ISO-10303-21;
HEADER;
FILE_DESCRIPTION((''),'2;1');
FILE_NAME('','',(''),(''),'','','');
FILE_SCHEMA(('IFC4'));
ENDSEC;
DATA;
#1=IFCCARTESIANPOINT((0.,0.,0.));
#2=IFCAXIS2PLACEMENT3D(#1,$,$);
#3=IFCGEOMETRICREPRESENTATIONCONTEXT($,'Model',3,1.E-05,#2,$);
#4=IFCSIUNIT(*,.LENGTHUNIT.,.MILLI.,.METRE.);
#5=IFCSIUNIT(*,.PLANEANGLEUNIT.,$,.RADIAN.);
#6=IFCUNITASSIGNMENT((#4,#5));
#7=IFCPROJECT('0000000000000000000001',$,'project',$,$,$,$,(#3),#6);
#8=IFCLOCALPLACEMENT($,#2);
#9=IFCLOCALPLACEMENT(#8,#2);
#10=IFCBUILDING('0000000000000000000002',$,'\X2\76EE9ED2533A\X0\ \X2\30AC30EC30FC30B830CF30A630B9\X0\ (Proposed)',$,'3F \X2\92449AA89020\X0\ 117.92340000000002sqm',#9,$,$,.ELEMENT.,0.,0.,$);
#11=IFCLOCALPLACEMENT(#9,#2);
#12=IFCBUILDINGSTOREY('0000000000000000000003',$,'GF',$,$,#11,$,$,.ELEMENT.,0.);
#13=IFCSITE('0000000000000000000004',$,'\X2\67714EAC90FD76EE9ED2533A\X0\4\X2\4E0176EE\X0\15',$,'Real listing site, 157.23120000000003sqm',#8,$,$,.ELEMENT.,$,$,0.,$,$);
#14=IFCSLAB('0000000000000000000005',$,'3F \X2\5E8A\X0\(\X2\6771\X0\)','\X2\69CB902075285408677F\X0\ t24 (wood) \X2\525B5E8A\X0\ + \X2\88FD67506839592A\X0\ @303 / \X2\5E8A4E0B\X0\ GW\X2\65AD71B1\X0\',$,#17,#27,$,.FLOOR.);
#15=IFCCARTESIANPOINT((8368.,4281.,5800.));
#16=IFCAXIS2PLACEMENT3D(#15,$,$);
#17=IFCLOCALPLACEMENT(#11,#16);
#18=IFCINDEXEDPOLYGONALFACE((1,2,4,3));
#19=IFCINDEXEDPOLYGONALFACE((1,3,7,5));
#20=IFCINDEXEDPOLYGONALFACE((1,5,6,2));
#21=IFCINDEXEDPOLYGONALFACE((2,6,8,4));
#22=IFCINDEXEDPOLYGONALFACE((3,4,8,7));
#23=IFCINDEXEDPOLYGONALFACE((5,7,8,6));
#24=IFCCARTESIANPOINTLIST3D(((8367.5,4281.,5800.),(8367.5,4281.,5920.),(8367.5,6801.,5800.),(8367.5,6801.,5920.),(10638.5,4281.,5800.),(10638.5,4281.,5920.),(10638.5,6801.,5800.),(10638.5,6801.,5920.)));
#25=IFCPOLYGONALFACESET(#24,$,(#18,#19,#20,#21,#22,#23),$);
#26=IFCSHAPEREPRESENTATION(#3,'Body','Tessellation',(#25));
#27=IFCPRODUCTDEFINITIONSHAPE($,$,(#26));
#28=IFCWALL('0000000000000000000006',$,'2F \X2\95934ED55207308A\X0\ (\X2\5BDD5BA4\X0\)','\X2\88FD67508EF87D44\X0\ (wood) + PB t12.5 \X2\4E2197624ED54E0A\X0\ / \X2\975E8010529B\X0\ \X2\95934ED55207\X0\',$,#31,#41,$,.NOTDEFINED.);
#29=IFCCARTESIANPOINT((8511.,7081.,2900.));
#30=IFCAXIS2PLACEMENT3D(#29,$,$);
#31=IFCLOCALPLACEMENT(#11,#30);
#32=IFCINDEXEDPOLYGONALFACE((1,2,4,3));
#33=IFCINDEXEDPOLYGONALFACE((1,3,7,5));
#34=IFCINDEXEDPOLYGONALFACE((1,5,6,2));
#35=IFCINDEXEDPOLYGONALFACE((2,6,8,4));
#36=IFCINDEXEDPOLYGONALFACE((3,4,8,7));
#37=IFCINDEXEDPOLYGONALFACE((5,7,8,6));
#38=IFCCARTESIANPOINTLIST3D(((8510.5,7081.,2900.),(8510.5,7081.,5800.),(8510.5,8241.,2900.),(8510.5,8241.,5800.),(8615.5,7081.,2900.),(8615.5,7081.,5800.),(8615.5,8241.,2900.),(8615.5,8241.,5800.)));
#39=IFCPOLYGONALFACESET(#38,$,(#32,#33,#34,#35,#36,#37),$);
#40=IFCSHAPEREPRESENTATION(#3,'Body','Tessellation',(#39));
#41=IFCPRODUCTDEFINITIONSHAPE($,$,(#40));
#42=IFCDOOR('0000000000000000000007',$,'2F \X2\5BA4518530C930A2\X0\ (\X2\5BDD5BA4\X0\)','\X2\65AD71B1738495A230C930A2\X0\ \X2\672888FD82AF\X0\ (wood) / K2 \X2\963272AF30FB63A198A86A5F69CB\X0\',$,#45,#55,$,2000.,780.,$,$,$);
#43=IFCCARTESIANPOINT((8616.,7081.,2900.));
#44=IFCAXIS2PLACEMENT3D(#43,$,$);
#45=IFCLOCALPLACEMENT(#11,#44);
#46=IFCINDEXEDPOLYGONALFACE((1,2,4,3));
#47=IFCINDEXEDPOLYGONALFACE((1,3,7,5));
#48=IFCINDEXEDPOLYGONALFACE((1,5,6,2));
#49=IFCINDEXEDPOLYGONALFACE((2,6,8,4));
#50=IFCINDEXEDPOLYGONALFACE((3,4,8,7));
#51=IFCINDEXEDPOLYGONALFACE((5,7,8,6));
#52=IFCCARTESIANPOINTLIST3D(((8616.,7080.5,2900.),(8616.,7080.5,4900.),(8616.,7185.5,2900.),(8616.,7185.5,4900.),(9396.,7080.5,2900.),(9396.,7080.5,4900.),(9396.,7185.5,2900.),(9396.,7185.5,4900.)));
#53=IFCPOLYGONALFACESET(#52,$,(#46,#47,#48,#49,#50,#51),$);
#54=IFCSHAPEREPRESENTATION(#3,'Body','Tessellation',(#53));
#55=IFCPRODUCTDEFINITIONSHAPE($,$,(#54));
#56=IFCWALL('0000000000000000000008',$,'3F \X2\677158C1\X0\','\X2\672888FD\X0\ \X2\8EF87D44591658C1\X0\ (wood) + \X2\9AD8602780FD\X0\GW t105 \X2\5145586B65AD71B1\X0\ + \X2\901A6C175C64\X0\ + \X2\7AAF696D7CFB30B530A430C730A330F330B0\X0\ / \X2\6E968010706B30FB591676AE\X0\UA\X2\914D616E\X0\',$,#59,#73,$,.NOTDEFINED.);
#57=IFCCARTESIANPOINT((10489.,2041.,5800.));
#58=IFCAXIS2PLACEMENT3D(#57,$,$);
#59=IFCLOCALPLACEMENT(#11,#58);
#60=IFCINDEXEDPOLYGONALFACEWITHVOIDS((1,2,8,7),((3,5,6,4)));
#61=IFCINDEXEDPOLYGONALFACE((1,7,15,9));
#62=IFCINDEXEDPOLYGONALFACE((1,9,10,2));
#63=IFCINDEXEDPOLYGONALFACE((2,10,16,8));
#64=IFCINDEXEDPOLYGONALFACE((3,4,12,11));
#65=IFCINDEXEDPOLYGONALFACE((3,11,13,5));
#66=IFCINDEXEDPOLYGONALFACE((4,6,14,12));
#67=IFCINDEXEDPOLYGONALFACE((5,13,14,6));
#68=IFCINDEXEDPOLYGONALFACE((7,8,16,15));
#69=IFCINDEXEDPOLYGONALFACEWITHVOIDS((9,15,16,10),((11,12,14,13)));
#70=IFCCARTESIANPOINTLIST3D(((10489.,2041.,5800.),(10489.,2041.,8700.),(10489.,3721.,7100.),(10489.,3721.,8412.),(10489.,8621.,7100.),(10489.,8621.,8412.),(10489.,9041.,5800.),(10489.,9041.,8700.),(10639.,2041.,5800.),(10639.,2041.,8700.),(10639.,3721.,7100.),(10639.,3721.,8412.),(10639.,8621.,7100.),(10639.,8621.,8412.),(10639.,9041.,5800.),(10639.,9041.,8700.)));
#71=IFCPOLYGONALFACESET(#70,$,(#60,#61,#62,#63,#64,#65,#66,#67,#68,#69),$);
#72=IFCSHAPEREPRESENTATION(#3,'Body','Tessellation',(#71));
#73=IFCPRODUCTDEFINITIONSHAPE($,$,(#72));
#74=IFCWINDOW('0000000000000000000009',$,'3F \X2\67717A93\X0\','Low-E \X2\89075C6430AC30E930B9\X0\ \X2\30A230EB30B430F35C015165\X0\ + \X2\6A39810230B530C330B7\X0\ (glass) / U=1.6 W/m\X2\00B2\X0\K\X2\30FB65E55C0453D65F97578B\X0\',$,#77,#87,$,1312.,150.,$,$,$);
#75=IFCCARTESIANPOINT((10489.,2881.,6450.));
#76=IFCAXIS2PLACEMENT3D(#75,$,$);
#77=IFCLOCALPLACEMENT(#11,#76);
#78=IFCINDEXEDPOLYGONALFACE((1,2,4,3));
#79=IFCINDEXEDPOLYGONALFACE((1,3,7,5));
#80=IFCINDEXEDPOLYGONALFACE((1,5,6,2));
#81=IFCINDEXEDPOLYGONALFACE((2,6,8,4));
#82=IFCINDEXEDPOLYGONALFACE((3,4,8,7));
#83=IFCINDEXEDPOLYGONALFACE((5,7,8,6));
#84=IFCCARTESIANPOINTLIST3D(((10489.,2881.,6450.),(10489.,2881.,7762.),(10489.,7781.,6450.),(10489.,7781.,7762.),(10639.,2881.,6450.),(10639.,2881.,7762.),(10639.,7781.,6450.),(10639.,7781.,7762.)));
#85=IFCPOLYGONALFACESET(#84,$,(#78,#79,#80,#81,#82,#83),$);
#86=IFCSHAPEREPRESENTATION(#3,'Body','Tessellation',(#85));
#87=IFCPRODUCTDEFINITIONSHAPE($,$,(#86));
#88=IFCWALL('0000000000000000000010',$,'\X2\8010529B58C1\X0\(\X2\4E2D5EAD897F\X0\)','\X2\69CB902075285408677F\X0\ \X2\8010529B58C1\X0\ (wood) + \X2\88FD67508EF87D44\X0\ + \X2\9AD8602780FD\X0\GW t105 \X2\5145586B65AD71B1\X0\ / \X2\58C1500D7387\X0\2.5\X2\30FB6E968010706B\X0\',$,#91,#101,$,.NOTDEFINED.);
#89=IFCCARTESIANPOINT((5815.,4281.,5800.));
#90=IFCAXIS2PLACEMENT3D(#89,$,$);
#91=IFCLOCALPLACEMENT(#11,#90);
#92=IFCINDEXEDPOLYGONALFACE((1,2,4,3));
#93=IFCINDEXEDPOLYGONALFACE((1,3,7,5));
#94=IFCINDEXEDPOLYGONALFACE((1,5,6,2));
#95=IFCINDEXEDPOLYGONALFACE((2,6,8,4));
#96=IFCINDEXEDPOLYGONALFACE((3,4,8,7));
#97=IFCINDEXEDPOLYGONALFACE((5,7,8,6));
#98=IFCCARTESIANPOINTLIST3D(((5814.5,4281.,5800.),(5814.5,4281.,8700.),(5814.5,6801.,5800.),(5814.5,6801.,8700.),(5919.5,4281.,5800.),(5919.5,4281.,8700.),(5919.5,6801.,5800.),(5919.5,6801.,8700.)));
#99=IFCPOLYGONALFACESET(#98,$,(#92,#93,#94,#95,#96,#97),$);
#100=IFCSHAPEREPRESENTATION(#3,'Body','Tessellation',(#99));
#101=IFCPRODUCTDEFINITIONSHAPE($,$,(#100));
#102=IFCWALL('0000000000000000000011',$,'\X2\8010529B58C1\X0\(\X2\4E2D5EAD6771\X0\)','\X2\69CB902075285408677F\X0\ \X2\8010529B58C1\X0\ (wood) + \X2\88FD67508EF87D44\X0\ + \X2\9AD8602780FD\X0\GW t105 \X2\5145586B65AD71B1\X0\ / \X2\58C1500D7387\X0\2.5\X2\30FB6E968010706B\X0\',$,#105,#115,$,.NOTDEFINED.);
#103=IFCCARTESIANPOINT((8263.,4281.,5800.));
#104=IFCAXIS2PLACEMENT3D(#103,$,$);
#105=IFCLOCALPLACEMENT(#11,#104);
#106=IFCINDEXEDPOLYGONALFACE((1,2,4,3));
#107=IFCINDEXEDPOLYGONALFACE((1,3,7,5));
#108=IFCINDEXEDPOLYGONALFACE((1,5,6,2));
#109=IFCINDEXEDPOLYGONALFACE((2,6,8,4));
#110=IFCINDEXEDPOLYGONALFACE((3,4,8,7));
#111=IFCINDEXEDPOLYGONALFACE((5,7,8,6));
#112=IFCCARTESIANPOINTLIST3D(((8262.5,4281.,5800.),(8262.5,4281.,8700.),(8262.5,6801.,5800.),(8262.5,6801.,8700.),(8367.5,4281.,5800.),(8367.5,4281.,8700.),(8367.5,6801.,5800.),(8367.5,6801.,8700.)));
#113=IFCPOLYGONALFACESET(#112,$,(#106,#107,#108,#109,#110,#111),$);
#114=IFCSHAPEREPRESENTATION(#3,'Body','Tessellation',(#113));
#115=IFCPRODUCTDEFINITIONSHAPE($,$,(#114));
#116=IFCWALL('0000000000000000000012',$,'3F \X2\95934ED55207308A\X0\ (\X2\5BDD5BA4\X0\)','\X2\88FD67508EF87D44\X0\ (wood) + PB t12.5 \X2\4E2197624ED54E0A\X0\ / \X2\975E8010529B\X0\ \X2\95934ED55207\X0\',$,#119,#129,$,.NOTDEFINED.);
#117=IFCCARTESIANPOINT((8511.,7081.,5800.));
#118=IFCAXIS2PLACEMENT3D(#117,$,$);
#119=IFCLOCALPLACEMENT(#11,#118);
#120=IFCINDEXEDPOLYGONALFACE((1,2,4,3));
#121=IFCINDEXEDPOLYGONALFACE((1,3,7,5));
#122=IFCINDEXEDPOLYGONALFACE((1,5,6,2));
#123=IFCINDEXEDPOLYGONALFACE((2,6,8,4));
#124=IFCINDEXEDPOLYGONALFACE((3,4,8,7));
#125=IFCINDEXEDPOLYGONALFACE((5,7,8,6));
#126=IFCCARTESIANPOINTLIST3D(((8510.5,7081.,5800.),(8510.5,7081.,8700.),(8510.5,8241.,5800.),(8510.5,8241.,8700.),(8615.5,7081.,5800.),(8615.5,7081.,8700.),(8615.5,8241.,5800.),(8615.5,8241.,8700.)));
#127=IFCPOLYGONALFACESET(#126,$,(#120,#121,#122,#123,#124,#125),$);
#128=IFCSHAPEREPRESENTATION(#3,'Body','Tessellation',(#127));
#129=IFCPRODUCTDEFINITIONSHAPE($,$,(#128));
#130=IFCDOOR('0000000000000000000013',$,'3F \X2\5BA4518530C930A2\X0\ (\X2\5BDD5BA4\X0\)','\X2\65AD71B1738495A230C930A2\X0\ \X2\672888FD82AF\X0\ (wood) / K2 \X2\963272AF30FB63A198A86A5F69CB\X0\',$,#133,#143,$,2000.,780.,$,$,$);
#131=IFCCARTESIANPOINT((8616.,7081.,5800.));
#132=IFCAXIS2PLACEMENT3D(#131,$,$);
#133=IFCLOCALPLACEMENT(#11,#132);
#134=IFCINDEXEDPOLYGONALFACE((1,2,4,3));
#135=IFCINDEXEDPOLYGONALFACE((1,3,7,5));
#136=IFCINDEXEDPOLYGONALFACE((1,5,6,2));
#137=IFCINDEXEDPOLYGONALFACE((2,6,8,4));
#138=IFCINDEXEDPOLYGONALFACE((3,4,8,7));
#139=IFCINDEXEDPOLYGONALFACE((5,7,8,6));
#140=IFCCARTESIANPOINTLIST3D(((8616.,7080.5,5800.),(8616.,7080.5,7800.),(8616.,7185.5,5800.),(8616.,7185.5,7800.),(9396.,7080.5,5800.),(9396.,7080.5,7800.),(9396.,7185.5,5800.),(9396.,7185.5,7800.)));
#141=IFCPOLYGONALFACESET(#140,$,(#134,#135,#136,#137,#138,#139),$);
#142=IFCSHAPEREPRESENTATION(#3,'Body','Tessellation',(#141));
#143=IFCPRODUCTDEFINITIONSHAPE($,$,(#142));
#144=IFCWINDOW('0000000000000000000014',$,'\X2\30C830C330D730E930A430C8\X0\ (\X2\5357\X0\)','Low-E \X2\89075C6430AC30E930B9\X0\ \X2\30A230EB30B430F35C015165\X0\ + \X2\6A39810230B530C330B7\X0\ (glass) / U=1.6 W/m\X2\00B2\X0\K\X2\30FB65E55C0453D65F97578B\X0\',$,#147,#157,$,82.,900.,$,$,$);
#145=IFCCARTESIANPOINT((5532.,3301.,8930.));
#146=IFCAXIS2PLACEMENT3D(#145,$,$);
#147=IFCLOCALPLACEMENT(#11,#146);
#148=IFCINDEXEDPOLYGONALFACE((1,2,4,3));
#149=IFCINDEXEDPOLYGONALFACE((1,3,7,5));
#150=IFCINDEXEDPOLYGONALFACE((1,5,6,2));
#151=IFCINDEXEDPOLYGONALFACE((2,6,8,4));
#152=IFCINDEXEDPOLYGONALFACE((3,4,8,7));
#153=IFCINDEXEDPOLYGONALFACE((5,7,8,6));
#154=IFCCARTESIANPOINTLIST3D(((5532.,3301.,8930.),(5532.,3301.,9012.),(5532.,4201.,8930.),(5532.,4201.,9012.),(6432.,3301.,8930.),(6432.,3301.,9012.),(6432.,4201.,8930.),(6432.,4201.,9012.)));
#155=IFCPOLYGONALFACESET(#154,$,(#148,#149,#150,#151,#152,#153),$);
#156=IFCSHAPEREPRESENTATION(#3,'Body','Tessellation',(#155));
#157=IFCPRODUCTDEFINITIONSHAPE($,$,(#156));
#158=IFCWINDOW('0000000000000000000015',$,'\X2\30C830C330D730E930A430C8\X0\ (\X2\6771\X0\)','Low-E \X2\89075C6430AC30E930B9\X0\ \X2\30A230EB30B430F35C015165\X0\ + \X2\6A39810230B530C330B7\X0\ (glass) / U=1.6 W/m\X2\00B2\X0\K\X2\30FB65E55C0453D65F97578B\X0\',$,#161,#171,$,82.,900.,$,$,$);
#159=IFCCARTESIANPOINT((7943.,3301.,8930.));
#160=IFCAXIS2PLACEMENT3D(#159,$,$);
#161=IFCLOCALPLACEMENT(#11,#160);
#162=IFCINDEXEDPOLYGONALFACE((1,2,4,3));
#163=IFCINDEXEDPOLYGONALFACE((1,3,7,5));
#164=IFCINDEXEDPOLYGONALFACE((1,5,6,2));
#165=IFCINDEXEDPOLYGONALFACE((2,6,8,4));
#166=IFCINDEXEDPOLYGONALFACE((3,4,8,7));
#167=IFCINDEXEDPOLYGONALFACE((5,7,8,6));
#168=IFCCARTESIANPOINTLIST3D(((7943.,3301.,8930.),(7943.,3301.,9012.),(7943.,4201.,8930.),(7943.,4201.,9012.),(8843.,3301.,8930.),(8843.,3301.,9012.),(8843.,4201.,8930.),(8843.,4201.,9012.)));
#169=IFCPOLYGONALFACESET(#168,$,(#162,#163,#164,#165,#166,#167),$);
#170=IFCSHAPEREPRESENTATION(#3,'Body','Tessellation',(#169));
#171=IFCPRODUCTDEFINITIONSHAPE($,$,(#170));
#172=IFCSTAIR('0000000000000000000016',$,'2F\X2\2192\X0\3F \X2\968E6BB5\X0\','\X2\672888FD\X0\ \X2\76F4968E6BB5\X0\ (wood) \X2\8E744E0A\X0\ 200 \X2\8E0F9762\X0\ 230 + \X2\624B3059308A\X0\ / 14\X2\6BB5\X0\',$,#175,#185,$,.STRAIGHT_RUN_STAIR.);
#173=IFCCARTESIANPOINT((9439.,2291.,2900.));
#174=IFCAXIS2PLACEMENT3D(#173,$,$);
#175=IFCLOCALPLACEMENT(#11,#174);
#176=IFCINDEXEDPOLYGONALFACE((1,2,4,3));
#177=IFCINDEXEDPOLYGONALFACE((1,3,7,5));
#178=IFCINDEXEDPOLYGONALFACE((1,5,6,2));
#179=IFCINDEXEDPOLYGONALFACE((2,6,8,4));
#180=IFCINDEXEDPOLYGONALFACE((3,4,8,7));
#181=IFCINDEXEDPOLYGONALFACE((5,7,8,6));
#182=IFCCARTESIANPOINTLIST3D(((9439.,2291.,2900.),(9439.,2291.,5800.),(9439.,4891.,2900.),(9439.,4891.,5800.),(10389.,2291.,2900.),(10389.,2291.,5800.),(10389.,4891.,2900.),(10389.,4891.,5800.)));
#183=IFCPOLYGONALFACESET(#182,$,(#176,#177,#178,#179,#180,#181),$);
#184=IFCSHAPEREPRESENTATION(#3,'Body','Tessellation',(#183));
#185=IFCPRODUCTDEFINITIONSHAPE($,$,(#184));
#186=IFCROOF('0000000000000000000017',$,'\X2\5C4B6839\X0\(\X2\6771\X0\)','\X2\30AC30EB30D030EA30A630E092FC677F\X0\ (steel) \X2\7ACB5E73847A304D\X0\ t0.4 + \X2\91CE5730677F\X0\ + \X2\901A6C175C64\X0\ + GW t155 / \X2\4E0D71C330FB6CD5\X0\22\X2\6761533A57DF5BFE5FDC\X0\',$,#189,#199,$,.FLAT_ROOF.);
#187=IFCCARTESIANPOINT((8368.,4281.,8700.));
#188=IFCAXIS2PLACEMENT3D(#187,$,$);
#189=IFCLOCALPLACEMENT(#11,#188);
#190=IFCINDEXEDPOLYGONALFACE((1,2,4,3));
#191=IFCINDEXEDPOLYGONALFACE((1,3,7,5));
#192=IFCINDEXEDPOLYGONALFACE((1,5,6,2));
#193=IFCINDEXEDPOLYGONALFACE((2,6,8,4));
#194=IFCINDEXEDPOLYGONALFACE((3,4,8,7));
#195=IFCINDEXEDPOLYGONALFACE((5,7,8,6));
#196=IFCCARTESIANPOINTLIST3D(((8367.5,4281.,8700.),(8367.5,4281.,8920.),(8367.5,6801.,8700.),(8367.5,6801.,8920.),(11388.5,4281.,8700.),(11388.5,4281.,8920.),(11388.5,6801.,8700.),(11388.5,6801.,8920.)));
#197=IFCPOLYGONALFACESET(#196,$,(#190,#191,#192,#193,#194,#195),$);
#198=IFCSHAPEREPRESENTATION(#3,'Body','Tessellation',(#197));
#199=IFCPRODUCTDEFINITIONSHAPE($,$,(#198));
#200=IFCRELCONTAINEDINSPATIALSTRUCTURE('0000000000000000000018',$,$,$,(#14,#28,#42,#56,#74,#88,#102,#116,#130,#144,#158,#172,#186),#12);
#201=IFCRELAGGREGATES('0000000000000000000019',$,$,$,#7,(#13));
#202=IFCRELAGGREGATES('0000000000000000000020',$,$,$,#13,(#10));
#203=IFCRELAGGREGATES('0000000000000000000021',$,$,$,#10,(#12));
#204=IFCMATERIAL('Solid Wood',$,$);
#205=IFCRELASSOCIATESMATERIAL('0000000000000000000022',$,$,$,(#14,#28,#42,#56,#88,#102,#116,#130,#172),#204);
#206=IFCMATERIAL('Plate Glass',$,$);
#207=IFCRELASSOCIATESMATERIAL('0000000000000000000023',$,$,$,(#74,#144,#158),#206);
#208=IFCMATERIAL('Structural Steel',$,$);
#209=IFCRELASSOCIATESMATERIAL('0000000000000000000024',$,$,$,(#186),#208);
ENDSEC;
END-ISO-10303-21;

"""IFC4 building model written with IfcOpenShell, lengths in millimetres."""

from ifc_helpers import new_model, si_unit, frame, frame_2d, origin, place, context, project, spatial, rectangle, extrude, material, element, fill, save


model = new_model("IFC4")

# Units and contexts
model_context = context("Model", 3, precision=1e-05, world=origin())
ifc_project = project(units=[si_unit("LENGTHUNIT", "METRE", prefix="MILLI"), si_unit("PLANEANGLEUNIT", "RADIAN")], contexts=[model_context])

# Site, building, storey
site_placement = place(None, origin())
site = spatial("IfcSite", under=ifc_project, at=site_placement, Name="東京都目黒区4丁目15", ObjectType="Real listing site, 157.23120000000003sqm", CompositionType="ELEMENT", RefElevation=0.0)
building_placement = place(site_placement, origin())
building = spatial("IfcBuilding", under=site, at=building_placement, Name="目黒区 ガレージハウス (Proposed)", ObjectType="3F 鉄骨造 117.92340000000002sqm", CompositionType="ELEMENT", ElevationOfRefHeight=0.0, ElevationOfTerrain=0.0)
storey_placement = place(building_placement, origin())
storey = spatial("IfcBuildingStorey", under=building, at=storey_placement, Name="GF", CompositionType="ELEMENT", Elevation=0.0)

# Slab
ifc_material_1 = material(Name="Solid Wood")
slab_placement = place(storey_placement, frame((8368.0, 4281.0, 5800.0)))
element("IfcSlab", 1, at=slab_placement, inside=storey, material=ifc_material_1, Name="3F 床(東)", Description="構造用合板 t24 (wood) 剛床 + 製材根太 @303 / 床下 GW断熱", PredefinedType="FLOOR", context=model_context, shape_type="SweptSolid", body=[
    extrude(rectangle(XDim=2271.0, YDim=2520.0, at=frame_2d((1135.0, 1260.0))), frame((8368.0, 4281.0, 5800.0)), (0.0, 0.0, 1.0), 120.0),
])

# Wall
wall_1_placement = place(storey_placement, frame((8511.0, 7081.0, 2900.0)))
element("IfcWall", 2, at=wall_1_placement, inside=storey, material=ifc_material_1, Name="2F 間仕切り (寝室)", Description="製材軸組 (wood) + PB t12.5 両面仕上 / 非耐力 間仕切", PredefinedType="NOTDEFINED", context=model_context, shape_type="SweptSolid", body=[
    extrude(rectangle(XDim=105.0, YDim=1160.0, at=frame_2d((52.0, 580.0))), frame((8511.0, 7081.0, 2900.0)), (0.0, 0.0, 1.0), 2900.0),
])

# Door
door_1_placement = place(storey_placement, frame((8616.0, 7081.0, 2900.0)))
element("IfcDoor", 3, at=door_1_placement, inside=storey, material=ifc_material_1, Name="2F 室内ドア (寝室)", Description="断熱玄関ドア 木製芯 (wood) / K2 防犯・採風機構", OverallHeight=2000.0, OverallWidth=780.0, context=model_context, shape_type="SweptSolid", body=[
    extrude(rectangle(XDim=780.0, YDim=105.0, at=frame_2d((390.0, 52.0))), frame((8616.0, 7081.0, 2900.0)), (0.0, 0.0, 1.0), 2000.0),
])

# Wall, opening, window
wall_2_placement = place(storey_placement, frame((10489.0, 2041.0, 5800.0)))
wall_2 = element("IfcWall", 4, at=wall_2_placement, inside=storey, material=ifc_material_1, Name="3F 東壁", Description="木製 軸組外壁 (wood) + 高性能GW t105 充填断熱 + 通気層 + 窯業系サイディング / 準耐火・外皮UA配慮", PredefinedType="NOTDEFINED", context=model_context, shape_type="SweptSolid", body=[
    extrude(rectangle(XDim=150.0, YDim=7000.0, at=frame_2d((75.0, 3500.0))), frame((10489.0, 2041.0, 5800.0)), (0.0, 0.0, 1.0), 2900.0),
])
opening_1_placement = place(storey_placement, frame((10489.0, 2881.0, 6450.0)))
opening_1 = element("IfcOpeningElement", 5, at=opening_1_placement, cuts=wall_2, PredefinedType="NOTDEFINED", context=model_context, shape_type="SweptSolid", body=[
    extrude(rectangle(XDim=150.0, YDim=4900.0, at=frame_2d((75.0, 2450.0))), frame((10489.0, 2881.0, 6450.0)), (0.0, 0.0, 1.0), 1312.0),
])
ifc_material_2 = material(Name="Plate Glass")
window_1_placement = place(storey_placement, frame((10489.0, 2881.0, 6450.0)))
window_1 = element("IfcWindow", 6, at=window_1_placement, inside=storey, material=ifc_material_2, Name="3F 東窓", Description="Low-E 複層ガラス アルゴン封入 + 樹脂サッシ (glass) / U=1.6 W/m²K・日射取得型", OverallHeight=1312.0, OverallWidth=150.0, context=model_context, shape_type="SweptSolid", body=[
    extrude(rectangle(XDim=150.0, YDim=4900.0, at=frame_2d((75.0, 2450.0))), frame((10489.0, 2881.0, 6450.0)), (0.0, 0.0, 1.0), 1312.0),
])
fill(opening_1, window_1)

# Walls
wall_3_placement = place(storey_placement, frame((5815.0, 4281.0, 5800.0)))
element("IfcWall", 7, at=wall_3_placement, inside=storey, material=ifc_material_1, Name="耐力壁(中庭西)", Description="構造用合板 耐力壁 (wood) + 製材軸組 + 高性能GW t105 充填断熱 / 壁倍率2.5・準耐火", PredefinedType="NOTDEFINED", context=model_context, shape_type="SweptSolid", body=[
    extrude(rectangle(XDim=105.0, YDim=2520.0, at=frame_2d((52.0, 1260.0))), frame((5815.0, 4281.0, 5800.0)), (0.0, 0.0, 1.0), 2900.0),
])
wall_4_placement = place(storey_placement, frame((8263.0, 4281.0, 5800.0)))
element("IfcWall", 8, at=wall_4_placement, inside=storey, material=ifc_material_1, Name="耐力壁(中庭東)", Description="構造用合板 耐力壁 (wood) + 製材軸組 + 高性能GW t105 充填断熱 / 壁倍率2.5・準耐火", PredefinedType="NOTDEFINED", context=model_context, shape_type="SweptSolid", body=[
    extrude(rectangle(XDim=105.0, YDim=2520.0, at=frame_2d((52.0, 1260.0))), frame((8263.0, 4281.0, 5800.0)), (0.0, 0.0, 1.0), 2900.0),
])
wall_5_placement = place(storey_placement, frame((8511.0, 7081.0, 5800.0)))
element("IfcWall", 9, at=wall_5_placement, inside=storey, material=ifc_material_1, Name="3F 間仕切り (寝室)", Description="製材軸組 (wood) + PB t12.5 両面仕上 / 非耐力 間仕切", PredefinedType="NOTDEFINED", context=model_context, shape_type="SweptSolid", body=[
    extrude(rectangle(XDim=105.0, YDim=1160.0, at=frame_2d((52.0, 580.0))), frame((8511.0, 7081.0, 5800.0)), (0.0, 0.0, 1.0), 2900.0),
])

# Door
door_2_placement = place(storey_placement, frame((8616.0, 7081.0, 5800.0)))
element("IfcDoor", 10, at=door_2_placement, inside=storey, material=ifc_material_1, Name="3F 室内ドア (寝室)", Description="断熱玄関ドア 木製芯 (wood) / K2 防犯・採風機構", OverallHeight=2000.0, OverallWidth=780.0, context=model_context, shape_type="SweptSolid", body=[
    extrude(rectangle(XDim=780.0, YDim=105.0, at=frame_2d((390.0, 52.0))), frame((8616.0, 7081.0, 5800.0)), (0.0, 0.0, 1.0), 2000.0),
])

# Windows
window_2_placement = place(storey_placement, frame((5532.0, 3301.0, 8930.0)))
element("IfcWindow", 11, at=window_2_placement, inside=storey, material=ifc_material_2, Name="トップライト (南)", Description="Low-E 複層ガラス アルゴン封入 + 樹脂サッシ (glass) / U=1.6 W/m²K・日射取得型", OverallHeight=82.0, OverallWidth=900.0, context=model_context, shape_type="SweptSolid", body=[
    extrude(rectangle(XDim=900.0, YDim=900.0, at=frame_2d((450.0, 450.0))), frame((5532.0, 3301.0, 8930.0)), (0.0, 0.0, 1.0), 82.0),
])
window_3_placement = place(storey_placement, frame((7943.0, 3301.0, 8930.0)))
element("IfcWindow", 12, at=window_3_placement, inside=storey, material=ifc_material_2, Name="トップライト (東)", Description="Low-E 複層ガラス アルゴン封入 + 樹脂サッシ (glass) / U=1.6 W/m²K・日射取得型", OverallHeight=82.0, OverallWidth=900.0, context=model_context, shape_type="SweptSolid", body=[
    extrude(rectangle(XDim=900.0, YDim=900.0, at=frame_2d((450.0, 450.0))), frame((7943.0, 3301.0, 8930.0)), (0.0, 0.0, 1.0), 82.0),
])

# Stair
stair_placement = place(storey_placement, frame((9439.0, 2291.0, 2900.0)))
element("IfcStair", 13, at=stair_placement, inside=storey, material=ifc_material_1, Name="2F→3F 階段", Description="木製 直階段 (wood) 蹴上 200 踏面 230 + 手すり / 14段", PredefinedType="STRAIGHT_RUN_STAIR", context=model_context, shape_type="SweptSolid", body=[
    extrude(rectangle(XDim=950.0, YDim=2600.0, at=frame_2d((475.0, 1300.0))), frame((9439.0, 2291.0, 2900.0)), (0.0, 0.0, 1.0), 2900.0),
])

# Roof
ifc_material_3 = material(Name="Structural Steel")
for number, where, name in (
    (14, (8368.0, 4281.0, 8700.0), "屋根(東)"),
):
    element("IfcRoof", number, at=place(storey_placement, frame(where)), inside=storey, material=ifc_material_3, Name=name, Description="ガルバリウム鋼板 (steel) 立平葺き t0.4 + 野地板 + 通気層 + GW t155 / 不燃・法22条区域対応", PredefinedType="FLAT_ROOF", context=model_context, shape_type="SweptSolid", body=[
        extrude(rectangle(XDim=3021.0, YDim=2520.0, at=frame_2d((1510.0, 1260.0))), frame((8368.0, 4281.0, 8700.0)), (0.0, 0.0, 1.0), 220.0),
    ])

save(model, "model.ifc")
